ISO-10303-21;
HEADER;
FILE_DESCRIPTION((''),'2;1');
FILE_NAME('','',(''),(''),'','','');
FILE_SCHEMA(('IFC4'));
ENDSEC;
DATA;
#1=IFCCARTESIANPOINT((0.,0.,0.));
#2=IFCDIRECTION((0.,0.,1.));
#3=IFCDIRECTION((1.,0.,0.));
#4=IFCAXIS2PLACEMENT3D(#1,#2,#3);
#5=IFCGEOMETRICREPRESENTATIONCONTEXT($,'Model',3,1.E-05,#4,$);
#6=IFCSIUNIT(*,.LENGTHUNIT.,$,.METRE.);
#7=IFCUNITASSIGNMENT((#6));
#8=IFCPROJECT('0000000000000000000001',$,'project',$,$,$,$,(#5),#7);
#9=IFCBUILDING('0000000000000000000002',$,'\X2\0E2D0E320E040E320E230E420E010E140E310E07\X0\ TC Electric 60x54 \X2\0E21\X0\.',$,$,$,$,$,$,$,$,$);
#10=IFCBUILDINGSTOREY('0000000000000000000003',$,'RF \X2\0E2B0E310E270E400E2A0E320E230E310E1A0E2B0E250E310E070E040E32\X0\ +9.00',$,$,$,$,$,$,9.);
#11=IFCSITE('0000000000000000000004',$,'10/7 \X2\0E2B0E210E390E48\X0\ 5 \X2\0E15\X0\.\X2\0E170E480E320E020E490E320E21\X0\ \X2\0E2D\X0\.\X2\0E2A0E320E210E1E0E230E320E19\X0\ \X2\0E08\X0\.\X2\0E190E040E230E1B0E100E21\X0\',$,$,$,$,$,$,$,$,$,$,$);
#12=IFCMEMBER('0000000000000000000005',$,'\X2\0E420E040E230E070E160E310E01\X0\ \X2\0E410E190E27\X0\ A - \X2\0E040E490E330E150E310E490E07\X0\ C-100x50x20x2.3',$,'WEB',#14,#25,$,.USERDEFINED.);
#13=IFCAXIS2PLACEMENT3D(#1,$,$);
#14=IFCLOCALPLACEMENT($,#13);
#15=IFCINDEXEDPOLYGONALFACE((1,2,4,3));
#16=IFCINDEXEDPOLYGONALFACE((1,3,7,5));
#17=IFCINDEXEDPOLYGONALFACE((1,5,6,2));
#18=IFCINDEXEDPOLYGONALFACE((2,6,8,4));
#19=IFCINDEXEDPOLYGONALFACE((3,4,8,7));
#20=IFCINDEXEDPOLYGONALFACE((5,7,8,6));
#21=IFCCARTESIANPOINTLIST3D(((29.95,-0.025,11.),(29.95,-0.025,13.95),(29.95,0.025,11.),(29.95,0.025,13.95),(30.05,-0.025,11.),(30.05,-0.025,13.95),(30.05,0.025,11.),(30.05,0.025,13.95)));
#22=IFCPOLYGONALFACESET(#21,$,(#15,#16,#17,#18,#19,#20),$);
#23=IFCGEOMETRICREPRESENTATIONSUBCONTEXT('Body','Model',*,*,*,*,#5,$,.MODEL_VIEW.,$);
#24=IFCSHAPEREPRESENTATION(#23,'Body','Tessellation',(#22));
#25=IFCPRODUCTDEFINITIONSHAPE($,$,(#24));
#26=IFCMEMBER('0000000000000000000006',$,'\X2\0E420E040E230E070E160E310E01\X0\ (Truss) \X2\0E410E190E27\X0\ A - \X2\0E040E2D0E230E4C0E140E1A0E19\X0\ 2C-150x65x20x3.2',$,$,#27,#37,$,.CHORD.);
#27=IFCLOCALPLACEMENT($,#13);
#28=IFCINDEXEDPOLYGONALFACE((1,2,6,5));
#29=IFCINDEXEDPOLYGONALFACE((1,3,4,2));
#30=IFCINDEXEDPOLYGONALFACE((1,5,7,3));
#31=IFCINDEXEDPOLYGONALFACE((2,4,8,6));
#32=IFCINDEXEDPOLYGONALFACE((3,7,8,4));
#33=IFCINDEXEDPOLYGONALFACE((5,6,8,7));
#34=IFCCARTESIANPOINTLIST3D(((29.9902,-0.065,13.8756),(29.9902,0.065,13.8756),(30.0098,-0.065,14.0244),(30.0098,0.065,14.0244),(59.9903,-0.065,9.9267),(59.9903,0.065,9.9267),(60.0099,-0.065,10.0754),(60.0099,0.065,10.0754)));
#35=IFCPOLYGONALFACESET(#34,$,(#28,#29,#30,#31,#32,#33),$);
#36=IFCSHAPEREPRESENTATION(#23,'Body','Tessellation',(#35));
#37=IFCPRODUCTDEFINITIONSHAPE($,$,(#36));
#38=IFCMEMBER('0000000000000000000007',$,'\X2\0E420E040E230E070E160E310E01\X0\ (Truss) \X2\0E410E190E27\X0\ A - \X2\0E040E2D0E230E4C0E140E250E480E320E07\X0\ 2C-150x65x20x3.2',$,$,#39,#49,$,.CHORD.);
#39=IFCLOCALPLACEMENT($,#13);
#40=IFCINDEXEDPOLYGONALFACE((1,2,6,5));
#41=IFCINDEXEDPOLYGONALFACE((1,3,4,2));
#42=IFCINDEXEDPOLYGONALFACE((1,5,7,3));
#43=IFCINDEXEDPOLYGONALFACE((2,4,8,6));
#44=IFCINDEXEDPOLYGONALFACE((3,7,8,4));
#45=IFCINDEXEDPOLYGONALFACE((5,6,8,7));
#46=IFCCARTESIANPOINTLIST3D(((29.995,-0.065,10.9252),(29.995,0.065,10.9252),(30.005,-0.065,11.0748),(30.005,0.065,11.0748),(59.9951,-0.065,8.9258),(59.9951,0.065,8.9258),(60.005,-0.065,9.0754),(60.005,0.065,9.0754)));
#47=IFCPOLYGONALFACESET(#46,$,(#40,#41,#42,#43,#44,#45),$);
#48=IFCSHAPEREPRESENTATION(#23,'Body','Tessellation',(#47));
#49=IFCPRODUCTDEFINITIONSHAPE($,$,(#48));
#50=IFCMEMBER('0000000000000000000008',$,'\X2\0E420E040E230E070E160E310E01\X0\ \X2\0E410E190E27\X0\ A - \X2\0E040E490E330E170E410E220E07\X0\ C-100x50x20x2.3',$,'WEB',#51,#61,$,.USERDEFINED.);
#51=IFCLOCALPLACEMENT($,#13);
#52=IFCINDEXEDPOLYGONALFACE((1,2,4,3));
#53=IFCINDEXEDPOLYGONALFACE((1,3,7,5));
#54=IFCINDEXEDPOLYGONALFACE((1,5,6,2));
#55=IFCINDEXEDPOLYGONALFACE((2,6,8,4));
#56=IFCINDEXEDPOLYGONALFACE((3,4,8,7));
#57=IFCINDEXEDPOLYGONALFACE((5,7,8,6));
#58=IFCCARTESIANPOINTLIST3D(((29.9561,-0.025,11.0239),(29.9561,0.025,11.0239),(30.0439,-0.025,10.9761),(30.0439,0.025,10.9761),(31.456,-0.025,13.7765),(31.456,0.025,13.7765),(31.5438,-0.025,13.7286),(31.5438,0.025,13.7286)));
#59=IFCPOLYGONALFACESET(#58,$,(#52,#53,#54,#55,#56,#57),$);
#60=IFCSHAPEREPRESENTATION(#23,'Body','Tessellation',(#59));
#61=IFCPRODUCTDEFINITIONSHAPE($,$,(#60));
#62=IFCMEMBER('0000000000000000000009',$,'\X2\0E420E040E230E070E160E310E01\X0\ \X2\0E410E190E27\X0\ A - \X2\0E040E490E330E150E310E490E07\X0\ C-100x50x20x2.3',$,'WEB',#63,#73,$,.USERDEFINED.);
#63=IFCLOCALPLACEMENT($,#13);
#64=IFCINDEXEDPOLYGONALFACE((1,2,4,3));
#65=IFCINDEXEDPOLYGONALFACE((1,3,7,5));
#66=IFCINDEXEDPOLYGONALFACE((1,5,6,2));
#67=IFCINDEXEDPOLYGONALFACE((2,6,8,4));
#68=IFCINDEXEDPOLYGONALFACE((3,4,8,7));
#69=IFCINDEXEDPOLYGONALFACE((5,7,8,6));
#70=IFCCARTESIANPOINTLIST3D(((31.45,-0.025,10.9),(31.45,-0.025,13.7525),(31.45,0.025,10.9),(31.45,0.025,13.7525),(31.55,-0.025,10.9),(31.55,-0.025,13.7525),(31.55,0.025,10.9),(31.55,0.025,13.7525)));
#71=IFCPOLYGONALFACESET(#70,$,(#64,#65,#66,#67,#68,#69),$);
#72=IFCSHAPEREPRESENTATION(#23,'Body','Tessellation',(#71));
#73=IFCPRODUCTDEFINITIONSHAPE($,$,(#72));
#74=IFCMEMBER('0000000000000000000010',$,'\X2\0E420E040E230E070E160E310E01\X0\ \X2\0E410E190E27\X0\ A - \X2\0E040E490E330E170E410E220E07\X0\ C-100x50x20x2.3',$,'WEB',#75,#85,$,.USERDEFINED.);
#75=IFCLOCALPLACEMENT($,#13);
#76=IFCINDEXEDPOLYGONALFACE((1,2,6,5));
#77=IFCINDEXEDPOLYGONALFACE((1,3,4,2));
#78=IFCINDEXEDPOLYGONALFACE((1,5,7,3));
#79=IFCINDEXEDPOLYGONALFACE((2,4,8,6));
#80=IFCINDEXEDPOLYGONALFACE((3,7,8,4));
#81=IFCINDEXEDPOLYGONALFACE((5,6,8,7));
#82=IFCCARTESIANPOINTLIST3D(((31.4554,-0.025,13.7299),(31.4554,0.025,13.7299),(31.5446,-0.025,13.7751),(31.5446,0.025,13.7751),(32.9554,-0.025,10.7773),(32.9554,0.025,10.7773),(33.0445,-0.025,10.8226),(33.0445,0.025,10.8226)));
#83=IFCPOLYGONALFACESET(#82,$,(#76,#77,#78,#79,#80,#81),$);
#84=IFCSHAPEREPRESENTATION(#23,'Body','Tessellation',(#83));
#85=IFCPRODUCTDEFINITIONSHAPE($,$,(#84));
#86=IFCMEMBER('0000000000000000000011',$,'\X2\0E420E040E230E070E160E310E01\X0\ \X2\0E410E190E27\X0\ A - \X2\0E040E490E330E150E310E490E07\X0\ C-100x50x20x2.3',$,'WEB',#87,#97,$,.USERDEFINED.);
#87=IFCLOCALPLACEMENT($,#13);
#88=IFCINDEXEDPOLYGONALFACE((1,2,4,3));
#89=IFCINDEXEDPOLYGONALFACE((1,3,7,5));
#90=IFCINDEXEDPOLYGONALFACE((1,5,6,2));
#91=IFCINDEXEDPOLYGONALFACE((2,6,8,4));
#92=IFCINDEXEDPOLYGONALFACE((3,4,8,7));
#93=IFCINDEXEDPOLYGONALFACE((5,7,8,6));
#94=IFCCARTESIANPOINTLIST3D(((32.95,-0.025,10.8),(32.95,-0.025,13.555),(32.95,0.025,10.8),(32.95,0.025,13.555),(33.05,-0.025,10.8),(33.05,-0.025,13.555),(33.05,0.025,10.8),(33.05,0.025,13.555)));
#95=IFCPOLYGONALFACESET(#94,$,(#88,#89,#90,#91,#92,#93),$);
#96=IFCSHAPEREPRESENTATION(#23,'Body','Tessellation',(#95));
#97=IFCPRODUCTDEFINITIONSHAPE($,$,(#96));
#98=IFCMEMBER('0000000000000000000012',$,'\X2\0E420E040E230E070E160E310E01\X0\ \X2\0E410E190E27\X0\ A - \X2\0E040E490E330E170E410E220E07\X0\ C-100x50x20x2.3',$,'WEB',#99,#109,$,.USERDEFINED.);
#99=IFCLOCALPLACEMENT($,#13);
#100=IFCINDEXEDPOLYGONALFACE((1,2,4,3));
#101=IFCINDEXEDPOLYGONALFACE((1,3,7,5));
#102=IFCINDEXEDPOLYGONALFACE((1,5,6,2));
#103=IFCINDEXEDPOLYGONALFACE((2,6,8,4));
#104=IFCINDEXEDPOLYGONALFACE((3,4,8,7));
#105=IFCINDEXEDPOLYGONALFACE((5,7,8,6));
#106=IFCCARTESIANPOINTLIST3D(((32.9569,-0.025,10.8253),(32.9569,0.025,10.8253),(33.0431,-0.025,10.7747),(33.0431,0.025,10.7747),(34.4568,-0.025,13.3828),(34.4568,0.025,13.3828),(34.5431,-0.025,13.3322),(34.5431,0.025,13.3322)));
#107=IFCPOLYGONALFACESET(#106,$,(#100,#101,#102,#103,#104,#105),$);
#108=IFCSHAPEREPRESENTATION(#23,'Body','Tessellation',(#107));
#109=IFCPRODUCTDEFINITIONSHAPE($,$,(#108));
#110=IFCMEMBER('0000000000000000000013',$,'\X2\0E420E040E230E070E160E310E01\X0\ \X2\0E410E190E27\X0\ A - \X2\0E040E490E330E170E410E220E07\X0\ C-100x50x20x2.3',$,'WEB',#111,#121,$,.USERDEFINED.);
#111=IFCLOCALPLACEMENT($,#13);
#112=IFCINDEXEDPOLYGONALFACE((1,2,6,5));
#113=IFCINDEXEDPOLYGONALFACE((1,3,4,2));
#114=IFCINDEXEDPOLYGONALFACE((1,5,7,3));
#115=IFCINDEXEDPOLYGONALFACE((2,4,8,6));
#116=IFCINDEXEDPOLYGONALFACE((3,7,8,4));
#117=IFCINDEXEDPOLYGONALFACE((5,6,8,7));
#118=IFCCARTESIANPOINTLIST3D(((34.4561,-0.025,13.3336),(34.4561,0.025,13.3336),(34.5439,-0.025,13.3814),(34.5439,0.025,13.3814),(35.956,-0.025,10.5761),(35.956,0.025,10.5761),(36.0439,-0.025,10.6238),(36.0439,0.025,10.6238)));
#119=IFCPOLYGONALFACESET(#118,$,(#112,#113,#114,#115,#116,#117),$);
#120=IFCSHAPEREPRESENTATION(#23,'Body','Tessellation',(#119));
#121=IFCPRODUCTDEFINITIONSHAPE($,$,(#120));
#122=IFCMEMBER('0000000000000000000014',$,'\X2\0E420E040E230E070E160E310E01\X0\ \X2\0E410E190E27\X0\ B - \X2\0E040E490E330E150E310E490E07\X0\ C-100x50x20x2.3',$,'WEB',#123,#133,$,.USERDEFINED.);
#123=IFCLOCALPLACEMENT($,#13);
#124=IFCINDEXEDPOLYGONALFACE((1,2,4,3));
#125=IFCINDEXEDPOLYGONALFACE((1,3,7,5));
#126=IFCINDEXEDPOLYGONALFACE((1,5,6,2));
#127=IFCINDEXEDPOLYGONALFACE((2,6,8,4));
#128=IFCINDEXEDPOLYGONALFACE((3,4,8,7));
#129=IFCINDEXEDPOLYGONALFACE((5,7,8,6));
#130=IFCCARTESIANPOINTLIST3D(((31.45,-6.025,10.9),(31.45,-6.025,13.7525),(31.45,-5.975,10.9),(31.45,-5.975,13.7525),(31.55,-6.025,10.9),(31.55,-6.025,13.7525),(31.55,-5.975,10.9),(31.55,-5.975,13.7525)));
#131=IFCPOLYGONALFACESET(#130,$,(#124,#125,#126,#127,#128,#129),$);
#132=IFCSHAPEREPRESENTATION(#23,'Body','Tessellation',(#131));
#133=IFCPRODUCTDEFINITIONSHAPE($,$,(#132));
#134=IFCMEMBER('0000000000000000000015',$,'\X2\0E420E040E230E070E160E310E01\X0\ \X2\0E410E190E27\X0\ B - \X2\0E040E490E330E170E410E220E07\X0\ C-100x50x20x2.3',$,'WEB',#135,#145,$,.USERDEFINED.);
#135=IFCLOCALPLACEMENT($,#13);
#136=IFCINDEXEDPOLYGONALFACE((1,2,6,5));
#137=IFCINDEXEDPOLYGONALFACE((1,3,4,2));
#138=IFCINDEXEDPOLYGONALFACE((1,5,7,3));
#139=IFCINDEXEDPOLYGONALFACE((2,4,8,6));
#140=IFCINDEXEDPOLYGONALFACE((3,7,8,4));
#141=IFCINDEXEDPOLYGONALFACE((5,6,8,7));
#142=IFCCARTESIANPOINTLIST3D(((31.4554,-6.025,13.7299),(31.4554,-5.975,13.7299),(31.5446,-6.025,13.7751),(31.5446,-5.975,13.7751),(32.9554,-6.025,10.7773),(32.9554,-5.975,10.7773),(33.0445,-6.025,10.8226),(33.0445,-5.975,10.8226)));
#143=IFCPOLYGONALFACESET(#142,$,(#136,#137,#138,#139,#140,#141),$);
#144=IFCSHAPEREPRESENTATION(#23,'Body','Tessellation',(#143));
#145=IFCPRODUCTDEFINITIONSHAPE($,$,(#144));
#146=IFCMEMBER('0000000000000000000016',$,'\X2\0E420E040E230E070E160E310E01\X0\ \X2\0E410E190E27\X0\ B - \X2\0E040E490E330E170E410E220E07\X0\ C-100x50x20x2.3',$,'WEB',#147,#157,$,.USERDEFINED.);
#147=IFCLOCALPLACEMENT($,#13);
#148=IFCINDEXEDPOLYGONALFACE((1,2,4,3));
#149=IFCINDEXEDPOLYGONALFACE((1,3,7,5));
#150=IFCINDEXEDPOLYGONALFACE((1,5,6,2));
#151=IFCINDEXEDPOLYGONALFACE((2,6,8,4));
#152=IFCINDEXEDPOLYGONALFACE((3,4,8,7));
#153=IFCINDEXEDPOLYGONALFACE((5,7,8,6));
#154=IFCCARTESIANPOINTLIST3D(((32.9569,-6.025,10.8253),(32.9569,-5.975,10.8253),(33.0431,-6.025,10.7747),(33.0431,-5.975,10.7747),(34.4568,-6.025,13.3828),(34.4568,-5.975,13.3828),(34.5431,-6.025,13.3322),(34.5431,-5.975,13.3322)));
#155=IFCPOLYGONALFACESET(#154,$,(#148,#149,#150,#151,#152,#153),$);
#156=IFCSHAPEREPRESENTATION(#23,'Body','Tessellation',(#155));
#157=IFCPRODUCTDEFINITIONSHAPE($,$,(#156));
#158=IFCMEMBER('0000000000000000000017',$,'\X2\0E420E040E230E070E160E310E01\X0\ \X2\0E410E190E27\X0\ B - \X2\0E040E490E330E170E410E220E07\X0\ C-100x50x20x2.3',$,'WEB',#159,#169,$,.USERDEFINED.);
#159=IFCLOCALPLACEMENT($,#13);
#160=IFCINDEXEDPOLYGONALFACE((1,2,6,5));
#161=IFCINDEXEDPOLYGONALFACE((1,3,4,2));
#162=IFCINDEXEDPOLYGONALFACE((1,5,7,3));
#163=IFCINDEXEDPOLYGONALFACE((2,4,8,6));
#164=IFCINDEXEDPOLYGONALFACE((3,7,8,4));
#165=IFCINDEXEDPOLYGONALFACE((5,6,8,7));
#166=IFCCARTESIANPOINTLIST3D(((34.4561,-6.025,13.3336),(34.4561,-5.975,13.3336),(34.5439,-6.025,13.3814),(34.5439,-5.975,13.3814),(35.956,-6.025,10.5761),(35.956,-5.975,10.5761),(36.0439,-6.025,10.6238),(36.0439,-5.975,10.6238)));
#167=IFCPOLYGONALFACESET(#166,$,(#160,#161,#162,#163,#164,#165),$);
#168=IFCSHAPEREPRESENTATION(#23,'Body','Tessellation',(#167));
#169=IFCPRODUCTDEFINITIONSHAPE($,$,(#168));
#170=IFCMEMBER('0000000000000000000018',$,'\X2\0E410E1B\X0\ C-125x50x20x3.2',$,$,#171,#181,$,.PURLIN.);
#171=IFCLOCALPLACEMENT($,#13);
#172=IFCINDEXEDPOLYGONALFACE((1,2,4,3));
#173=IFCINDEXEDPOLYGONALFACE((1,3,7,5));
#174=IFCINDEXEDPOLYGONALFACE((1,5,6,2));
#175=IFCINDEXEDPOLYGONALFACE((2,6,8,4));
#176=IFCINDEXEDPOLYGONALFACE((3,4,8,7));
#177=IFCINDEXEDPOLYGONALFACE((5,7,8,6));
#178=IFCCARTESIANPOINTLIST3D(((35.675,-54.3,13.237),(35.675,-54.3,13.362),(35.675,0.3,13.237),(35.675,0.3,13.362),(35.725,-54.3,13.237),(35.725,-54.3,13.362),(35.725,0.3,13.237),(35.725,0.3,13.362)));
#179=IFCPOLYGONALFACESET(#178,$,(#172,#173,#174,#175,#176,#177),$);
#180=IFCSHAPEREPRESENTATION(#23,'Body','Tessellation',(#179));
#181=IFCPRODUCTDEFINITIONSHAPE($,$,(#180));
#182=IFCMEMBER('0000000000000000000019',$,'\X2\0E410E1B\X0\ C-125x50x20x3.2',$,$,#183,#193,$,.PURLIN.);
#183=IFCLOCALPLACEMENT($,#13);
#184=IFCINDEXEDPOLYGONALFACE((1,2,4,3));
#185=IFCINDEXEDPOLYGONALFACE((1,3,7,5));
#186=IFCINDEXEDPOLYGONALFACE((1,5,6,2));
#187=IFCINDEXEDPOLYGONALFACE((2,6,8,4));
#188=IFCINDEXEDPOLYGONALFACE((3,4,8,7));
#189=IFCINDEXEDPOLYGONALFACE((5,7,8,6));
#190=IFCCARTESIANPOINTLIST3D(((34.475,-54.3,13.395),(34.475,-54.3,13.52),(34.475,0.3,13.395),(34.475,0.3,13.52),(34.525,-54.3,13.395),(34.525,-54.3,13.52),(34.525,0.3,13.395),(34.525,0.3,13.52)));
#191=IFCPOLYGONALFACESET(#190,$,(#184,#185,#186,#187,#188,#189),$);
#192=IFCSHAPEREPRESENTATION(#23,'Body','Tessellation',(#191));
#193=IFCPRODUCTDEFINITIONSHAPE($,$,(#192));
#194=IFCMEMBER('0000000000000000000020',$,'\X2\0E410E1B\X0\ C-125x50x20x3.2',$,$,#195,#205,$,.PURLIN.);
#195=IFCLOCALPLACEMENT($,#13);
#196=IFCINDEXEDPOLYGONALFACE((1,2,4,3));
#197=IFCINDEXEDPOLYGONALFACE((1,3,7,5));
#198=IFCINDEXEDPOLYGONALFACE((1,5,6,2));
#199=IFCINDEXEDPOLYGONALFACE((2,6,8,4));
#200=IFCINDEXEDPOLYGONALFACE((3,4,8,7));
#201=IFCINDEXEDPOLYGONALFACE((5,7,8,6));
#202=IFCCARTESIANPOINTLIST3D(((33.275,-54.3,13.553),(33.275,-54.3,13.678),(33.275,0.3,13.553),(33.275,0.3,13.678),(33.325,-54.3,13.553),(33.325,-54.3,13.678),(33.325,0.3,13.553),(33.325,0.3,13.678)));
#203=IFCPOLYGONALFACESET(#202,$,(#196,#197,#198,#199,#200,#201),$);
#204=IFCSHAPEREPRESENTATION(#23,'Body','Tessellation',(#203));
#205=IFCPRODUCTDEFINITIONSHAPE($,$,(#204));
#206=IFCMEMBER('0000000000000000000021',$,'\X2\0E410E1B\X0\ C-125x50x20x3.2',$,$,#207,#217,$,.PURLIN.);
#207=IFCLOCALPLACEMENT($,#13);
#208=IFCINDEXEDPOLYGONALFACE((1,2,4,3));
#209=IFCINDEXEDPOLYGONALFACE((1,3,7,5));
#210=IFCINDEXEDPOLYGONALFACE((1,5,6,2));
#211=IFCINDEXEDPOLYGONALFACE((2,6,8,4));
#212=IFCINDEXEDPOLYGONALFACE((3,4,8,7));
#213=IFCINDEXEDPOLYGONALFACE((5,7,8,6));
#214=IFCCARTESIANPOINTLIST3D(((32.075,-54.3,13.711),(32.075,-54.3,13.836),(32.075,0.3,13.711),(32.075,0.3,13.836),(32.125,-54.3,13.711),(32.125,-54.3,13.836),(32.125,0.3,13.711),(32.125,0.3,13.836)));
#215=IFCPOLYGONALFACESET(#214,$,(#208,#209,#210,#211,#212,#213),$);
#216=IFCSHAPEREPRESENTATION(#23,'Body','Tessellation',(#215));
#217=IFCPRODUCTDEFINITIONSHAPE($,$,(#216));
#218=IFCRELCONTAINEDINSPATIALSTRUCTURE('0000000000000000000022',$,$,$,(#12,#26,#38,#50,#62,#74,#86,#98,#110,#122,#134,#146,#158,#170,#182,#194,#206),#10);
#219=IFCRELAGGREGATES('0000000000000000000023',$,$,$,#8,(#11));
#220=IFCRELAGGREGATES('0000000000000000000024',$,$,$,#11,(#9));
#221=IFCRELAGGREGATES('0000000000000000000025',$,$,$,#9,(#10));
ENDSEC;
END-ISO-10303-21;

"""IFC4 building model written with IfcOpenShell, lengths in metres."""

from ifc_helpers import new_model, si_unit, frame, origin, origin_with_axes, origin_2d, place, context, subcontext, project, spatial, rectangle, extrude, element, save


model = new_model("IFC4")

# Units and contexts
model_context = context("Model", 3, precision=1e-05, world=origin_with_axes())
body_context = subcontext(model_context, "Body", "Model", "MODEL_VIEW")
ifc_project = project(units=[si_unit("LENGTHUNIT", "METRE")], contexts=[model_context])

# Site, building, storey
site = spatial("IfcSite", under=ifc_project, Name="10/7 หมู่ 5 ต.ท่าข้าม อ.สามพราน จ.นครปฐม")
building = spatial("IfcBuilding", under=site, Name="อาคารโกดัง TC Electric 60x54 ม.")
storey = spatial("IfcBuildingStorey", under=building, Name="RF หัวเสารับหลังคา +9.00", Elevation=9.0)

# Members
member_1_placement = place(None, frame((30.0, 0.0, 11.0), z_axis=(0.0, 0.0, 1.0), x_axis=(0.0, 1.0, 0.0)))
element("IfcMember", 1, at=member_1_placement, inside=storey, Name="โครงถัก แนว A - ค้ำตั้ง C-100x50x20x2.3", ObjectType="WEB", PredefinedType="USERDEFINED", context=body_context, shape_type="SweptSolid", body=[
    extrude(rectangle(XDim=0.05, YDim=0.1, at=origin_2d()), origin(), (0.0, 0.0, 1.0), 2.95),
])
member_2_placement = place(None, frame((30.0, 0.0, 13.95), z_axis=(0.9914, 0.0, -0.1305), x_axis=(0.0, -1.0, 0.0)))
element("IfcMember", 2, at=member_2_placement, inside=storey, Name="โครงถัก (Truss) แนว A - คอร์ดบน 2C-150x65x20x3.2", PredefinedType="CHORD", context=body_context, shape_type="SweptSolid", body=[
    extrude(rectangle(XDim=0.13, YDim=0.15, at=origin_2d()), origin(), (0.0, 0.0, 1.0), 30.2589),
])
member_3_placement = place(None, frame((30.0, 0.0, 11.0), z_axis=(0.9978, 0.0, -0.0665), x_axis=(0.0, -1.0, 0.0)))
element("IfcMember", 3, at=member_3_placement, inside=storey, Name="โครงถัก (Truss) แนว A - คอร์ดล่าง 2C-150x65x20x3.2", PredefinedType="CHORD", context=body_context, shape_type="SweptSolid", body=[
    extrude(rectangle(XDim=0.13, YDim=0.15, at=origin_2d()), origin(), (0.0, 0.0, 1.0), 30.0666),
])
member_4_placement = place(None, frame((30.0, 0.0, 11.0), z_axis=(0.4785, 0.0, 0.8781), x_axis=(0.0, -1.0, 0.0)))
element("IfcMember", 4, at=member_4_placement, inside=storey, Name="โครงถัก แนว A - ค้ำทแยง C-100x50x20x2.3", ObjectType="WEB", PredefinedType="USERDEFINED", context=body_context, shape_type="SweptSolid", body=[
    extrude(rectangle(XDim=0.05, YDim=0.1, at=origin_2d()), origin(), (0.0, 0.0, 1.0), 3.1347),
])
member_5_placement = place(None, frame((31.5, 0.0, 10.9), z_axis=(0.0, 0.0, 1.0), x_axis=(0.0, 1.0, 0.0)))
element("IfcMember", 5, at=member_5_placement, inside=storey, Name="โครงถัก แนว A - ค้ำตั้ง C-100x50x20x2.3", ObjectType="WEB", PredefinedType="USERDEFINED", context=body_context, shape_type="SweptSolid", body=[
    extrude(rectangle(XDim=0.05, YDim=0.1, at=origin_2d()), origin(), (0.0, 0.0, 1.0), 2.8525),
])
member_6_placement = place(None, frame((31.5, 0.0, 13.7525), z_axis=(0.4529, 0.0, -0.8915), x_axis=(0.0, -1.0, 0.0)))
element("IfcMember", 6, at=member_6_placement, inside=storey, Name="โครงถัก แนว A - ค้ำทแยง C-100x50x20x2.3", ObjectType="WEB", PredefinedType="USERDEFINED", context=body_context, shape_type="SweptSolid", body=[
    extrude(rectangle(XDim=0.05, YDim=0.1, at=origin_2d()), origin(), (0.0, 0.0, 1.0), 3.3117),
])
member_7_placement = place(None, frame((33.0, 0.0, 10.8), z_axis=(0.0, 0.0, 1.0), x_axis=(0.0, 1.0, 0.0)))
element("IfcMember", 7, at=member_7_placement, inside=storey, Name="โครงถัก แนว A - ค้ำตั้ง C-100x50x20x2.3", ObjectType="WEB", PredefinedType="USERDEFINED", context=body_context, shape_type="SweptSolid", body=[
    extrude(rectangle(XDim=0.05, YDim=0.1, at=origin_2d()), origin(), (0.0, 0.0, 1.0), 2.755),
])
member_8_placement = place(None, frame((33.0, 0.0, 10.8), z_axis=(0.5059, 0.0, 0.8626), x_axis=(0.0, -1.0, 0.0)))
element("IfcMember", 8, at=member_8_placement, inside=storey, Name="โครงถัก แนว A - ค้ำทแยง C-100x50x20x2.3", ObjectType="WEB", PredefinedType="USERDEFINED", context=body_context, shape_type="SweptSolid", body=[
    extrude(rectangle(XDim=0.05, YDim=0.1, at=origin_2d()), origin(), (0.0, 0.0, 1.0), 2.9649),
])
member_9_placement = place(None, frame((34.5, 0.0, 13.3575), z_axis=(0.4778, 0.0, -0.8784), x_axis=(0.0, -1.0, 0.0)))
element("IfcMember", 9, at=member_9_placement, inside=storey, Name="โครงถัก แนว A - ค้ำทแยง C-100x50x20x2.3", ObjectType="WEB", PredefinedType="USERDEFINED", context=body_context, shape_type="SweptSolid", body=[
    extrude(rectangle(XDim=0.05, YDim=0.1, at=origin_2d()), origin(), (0.0, 0.0, 1.0), 3.1391),
])
member_10_placement = place(None, frame((31.5, -6.0, 10.9), z_axis=(0.0, 0.0, 1.0), x_axis=(0.0, 1.0, 0.0)))
element("IfcMember", 10, at=member_10_placement, inside=storey, Name="โครงถัก แนว B - ค้ำตั้ง C-100x50x20x2.3", ObjectType="WEB", PredefinedType="USERDEFINED", context=body_context, shape_type="SweptSolid", body=[
    extrude(rectangle(XDim=0.05, YDim=0.1, at=origin_2d()), origin(), (0.0, 0.0, 1.0), 2.8525),
])
member_11_placement = place(None, frame((31.5, -6.0, 13.7525), z_axis=(0.4529, 0.0, -0.8915), x_axis=(0.0, -1.0, 0.0)))
element("IfcMember", 11, at=member_11_placement, inside=storey, Name="โครงถัก แนว B - ค้ำทแยง C-100x50x20x2.3", ObjectType="WEB", PredefinedType="USERDEFINED", context=body_context, shape_type="SweptSolid", body=[
    extrude(rectangle(XDim=0.05, YDim=0.1, at=origin_2d()), origin(), (0.0, 0.0, 1.0), 3.3117),
])
member_12_placement = place(None, frame((33.0, -6.0, 10.8), z_axis=(0.5059, 0.0, 0.8626), x_axis=(0.0, -1.0, 0.0)))
element("IfcMember", 12, at=member_12_placement, inside=storey, Name="โครงถัก แนว B - ค้ำทแยง C-100x50x20x2.3", ObjectType="WEB", PredefinedType="USERDEFINED", context=body_context, shape_type="SweptSolid", body=[
    extrude(rectangle(XDim=0.05, YDim=0.1, at=origin_2d()), origin(), (0.0, 0.0, 1.0), 2.9649),
])
member_13_placement = place(None, frame((34.5, -6.0, 13.3575), z_axis=(0.4778, 0.0, -0.8784), x_axis=(0.0, -1.0, 0.0)))
element("IfcMember", 13, at=member_13_placement, inside=storey, Name="โครงถัก แนว B - ค้ำทแยง C-100x50x20x2.3", ObjectType="WEB", PredefinedType="USERDEFINED", context=body_context, shape_type="SweptSolid", body=[
    extrude(rectangle(XDim=0.05, YDim=0.1, at=origin_2d()), origin(), (0.0, 0.0, 1.0), 3.1391),
])
for number, where, z_axis, x_axis, name in (
    (14, (35.7, 0.3, 13.2995), (0.0, -1.0, 0.0), (-1.0, 0.0, 0.0), "แป C-125x50x20x3.2"),
    (15, (34.5, 0.3, 13.4575), (0.0, -1.0, 0.0), (-1.0, 0.0, 0.0), "แป C-125x50x20x3.2"),
    (16, (33.3, 0.3, 13.6155), (0.0, -1.0, 0.0), (-1.0, 0.0, 0.0), "แป C-125x50x20x3.2"),
    (17, (32.1, 0.3, 13.7735), (0.0, -1.0, 0.0), (-1.0, 0.0, 0.0), "แป C-125x50x20x3.2"),
):
    element("IfcMember", number, at=place(None, frame(where, z_axis=z_axis, x_axis=x_axis)), inside=storey, Name=name, PredefinedType="PURLIN", context=body_context, shape_type="SweptSolid", body=[
        extrude(rectangle(XDim=0.05, YDim=0.125, at=origin_2d()), origin(), (0.0, 0.0, 1.0), 54.6),
    ])

save(model, "model.ifc")
